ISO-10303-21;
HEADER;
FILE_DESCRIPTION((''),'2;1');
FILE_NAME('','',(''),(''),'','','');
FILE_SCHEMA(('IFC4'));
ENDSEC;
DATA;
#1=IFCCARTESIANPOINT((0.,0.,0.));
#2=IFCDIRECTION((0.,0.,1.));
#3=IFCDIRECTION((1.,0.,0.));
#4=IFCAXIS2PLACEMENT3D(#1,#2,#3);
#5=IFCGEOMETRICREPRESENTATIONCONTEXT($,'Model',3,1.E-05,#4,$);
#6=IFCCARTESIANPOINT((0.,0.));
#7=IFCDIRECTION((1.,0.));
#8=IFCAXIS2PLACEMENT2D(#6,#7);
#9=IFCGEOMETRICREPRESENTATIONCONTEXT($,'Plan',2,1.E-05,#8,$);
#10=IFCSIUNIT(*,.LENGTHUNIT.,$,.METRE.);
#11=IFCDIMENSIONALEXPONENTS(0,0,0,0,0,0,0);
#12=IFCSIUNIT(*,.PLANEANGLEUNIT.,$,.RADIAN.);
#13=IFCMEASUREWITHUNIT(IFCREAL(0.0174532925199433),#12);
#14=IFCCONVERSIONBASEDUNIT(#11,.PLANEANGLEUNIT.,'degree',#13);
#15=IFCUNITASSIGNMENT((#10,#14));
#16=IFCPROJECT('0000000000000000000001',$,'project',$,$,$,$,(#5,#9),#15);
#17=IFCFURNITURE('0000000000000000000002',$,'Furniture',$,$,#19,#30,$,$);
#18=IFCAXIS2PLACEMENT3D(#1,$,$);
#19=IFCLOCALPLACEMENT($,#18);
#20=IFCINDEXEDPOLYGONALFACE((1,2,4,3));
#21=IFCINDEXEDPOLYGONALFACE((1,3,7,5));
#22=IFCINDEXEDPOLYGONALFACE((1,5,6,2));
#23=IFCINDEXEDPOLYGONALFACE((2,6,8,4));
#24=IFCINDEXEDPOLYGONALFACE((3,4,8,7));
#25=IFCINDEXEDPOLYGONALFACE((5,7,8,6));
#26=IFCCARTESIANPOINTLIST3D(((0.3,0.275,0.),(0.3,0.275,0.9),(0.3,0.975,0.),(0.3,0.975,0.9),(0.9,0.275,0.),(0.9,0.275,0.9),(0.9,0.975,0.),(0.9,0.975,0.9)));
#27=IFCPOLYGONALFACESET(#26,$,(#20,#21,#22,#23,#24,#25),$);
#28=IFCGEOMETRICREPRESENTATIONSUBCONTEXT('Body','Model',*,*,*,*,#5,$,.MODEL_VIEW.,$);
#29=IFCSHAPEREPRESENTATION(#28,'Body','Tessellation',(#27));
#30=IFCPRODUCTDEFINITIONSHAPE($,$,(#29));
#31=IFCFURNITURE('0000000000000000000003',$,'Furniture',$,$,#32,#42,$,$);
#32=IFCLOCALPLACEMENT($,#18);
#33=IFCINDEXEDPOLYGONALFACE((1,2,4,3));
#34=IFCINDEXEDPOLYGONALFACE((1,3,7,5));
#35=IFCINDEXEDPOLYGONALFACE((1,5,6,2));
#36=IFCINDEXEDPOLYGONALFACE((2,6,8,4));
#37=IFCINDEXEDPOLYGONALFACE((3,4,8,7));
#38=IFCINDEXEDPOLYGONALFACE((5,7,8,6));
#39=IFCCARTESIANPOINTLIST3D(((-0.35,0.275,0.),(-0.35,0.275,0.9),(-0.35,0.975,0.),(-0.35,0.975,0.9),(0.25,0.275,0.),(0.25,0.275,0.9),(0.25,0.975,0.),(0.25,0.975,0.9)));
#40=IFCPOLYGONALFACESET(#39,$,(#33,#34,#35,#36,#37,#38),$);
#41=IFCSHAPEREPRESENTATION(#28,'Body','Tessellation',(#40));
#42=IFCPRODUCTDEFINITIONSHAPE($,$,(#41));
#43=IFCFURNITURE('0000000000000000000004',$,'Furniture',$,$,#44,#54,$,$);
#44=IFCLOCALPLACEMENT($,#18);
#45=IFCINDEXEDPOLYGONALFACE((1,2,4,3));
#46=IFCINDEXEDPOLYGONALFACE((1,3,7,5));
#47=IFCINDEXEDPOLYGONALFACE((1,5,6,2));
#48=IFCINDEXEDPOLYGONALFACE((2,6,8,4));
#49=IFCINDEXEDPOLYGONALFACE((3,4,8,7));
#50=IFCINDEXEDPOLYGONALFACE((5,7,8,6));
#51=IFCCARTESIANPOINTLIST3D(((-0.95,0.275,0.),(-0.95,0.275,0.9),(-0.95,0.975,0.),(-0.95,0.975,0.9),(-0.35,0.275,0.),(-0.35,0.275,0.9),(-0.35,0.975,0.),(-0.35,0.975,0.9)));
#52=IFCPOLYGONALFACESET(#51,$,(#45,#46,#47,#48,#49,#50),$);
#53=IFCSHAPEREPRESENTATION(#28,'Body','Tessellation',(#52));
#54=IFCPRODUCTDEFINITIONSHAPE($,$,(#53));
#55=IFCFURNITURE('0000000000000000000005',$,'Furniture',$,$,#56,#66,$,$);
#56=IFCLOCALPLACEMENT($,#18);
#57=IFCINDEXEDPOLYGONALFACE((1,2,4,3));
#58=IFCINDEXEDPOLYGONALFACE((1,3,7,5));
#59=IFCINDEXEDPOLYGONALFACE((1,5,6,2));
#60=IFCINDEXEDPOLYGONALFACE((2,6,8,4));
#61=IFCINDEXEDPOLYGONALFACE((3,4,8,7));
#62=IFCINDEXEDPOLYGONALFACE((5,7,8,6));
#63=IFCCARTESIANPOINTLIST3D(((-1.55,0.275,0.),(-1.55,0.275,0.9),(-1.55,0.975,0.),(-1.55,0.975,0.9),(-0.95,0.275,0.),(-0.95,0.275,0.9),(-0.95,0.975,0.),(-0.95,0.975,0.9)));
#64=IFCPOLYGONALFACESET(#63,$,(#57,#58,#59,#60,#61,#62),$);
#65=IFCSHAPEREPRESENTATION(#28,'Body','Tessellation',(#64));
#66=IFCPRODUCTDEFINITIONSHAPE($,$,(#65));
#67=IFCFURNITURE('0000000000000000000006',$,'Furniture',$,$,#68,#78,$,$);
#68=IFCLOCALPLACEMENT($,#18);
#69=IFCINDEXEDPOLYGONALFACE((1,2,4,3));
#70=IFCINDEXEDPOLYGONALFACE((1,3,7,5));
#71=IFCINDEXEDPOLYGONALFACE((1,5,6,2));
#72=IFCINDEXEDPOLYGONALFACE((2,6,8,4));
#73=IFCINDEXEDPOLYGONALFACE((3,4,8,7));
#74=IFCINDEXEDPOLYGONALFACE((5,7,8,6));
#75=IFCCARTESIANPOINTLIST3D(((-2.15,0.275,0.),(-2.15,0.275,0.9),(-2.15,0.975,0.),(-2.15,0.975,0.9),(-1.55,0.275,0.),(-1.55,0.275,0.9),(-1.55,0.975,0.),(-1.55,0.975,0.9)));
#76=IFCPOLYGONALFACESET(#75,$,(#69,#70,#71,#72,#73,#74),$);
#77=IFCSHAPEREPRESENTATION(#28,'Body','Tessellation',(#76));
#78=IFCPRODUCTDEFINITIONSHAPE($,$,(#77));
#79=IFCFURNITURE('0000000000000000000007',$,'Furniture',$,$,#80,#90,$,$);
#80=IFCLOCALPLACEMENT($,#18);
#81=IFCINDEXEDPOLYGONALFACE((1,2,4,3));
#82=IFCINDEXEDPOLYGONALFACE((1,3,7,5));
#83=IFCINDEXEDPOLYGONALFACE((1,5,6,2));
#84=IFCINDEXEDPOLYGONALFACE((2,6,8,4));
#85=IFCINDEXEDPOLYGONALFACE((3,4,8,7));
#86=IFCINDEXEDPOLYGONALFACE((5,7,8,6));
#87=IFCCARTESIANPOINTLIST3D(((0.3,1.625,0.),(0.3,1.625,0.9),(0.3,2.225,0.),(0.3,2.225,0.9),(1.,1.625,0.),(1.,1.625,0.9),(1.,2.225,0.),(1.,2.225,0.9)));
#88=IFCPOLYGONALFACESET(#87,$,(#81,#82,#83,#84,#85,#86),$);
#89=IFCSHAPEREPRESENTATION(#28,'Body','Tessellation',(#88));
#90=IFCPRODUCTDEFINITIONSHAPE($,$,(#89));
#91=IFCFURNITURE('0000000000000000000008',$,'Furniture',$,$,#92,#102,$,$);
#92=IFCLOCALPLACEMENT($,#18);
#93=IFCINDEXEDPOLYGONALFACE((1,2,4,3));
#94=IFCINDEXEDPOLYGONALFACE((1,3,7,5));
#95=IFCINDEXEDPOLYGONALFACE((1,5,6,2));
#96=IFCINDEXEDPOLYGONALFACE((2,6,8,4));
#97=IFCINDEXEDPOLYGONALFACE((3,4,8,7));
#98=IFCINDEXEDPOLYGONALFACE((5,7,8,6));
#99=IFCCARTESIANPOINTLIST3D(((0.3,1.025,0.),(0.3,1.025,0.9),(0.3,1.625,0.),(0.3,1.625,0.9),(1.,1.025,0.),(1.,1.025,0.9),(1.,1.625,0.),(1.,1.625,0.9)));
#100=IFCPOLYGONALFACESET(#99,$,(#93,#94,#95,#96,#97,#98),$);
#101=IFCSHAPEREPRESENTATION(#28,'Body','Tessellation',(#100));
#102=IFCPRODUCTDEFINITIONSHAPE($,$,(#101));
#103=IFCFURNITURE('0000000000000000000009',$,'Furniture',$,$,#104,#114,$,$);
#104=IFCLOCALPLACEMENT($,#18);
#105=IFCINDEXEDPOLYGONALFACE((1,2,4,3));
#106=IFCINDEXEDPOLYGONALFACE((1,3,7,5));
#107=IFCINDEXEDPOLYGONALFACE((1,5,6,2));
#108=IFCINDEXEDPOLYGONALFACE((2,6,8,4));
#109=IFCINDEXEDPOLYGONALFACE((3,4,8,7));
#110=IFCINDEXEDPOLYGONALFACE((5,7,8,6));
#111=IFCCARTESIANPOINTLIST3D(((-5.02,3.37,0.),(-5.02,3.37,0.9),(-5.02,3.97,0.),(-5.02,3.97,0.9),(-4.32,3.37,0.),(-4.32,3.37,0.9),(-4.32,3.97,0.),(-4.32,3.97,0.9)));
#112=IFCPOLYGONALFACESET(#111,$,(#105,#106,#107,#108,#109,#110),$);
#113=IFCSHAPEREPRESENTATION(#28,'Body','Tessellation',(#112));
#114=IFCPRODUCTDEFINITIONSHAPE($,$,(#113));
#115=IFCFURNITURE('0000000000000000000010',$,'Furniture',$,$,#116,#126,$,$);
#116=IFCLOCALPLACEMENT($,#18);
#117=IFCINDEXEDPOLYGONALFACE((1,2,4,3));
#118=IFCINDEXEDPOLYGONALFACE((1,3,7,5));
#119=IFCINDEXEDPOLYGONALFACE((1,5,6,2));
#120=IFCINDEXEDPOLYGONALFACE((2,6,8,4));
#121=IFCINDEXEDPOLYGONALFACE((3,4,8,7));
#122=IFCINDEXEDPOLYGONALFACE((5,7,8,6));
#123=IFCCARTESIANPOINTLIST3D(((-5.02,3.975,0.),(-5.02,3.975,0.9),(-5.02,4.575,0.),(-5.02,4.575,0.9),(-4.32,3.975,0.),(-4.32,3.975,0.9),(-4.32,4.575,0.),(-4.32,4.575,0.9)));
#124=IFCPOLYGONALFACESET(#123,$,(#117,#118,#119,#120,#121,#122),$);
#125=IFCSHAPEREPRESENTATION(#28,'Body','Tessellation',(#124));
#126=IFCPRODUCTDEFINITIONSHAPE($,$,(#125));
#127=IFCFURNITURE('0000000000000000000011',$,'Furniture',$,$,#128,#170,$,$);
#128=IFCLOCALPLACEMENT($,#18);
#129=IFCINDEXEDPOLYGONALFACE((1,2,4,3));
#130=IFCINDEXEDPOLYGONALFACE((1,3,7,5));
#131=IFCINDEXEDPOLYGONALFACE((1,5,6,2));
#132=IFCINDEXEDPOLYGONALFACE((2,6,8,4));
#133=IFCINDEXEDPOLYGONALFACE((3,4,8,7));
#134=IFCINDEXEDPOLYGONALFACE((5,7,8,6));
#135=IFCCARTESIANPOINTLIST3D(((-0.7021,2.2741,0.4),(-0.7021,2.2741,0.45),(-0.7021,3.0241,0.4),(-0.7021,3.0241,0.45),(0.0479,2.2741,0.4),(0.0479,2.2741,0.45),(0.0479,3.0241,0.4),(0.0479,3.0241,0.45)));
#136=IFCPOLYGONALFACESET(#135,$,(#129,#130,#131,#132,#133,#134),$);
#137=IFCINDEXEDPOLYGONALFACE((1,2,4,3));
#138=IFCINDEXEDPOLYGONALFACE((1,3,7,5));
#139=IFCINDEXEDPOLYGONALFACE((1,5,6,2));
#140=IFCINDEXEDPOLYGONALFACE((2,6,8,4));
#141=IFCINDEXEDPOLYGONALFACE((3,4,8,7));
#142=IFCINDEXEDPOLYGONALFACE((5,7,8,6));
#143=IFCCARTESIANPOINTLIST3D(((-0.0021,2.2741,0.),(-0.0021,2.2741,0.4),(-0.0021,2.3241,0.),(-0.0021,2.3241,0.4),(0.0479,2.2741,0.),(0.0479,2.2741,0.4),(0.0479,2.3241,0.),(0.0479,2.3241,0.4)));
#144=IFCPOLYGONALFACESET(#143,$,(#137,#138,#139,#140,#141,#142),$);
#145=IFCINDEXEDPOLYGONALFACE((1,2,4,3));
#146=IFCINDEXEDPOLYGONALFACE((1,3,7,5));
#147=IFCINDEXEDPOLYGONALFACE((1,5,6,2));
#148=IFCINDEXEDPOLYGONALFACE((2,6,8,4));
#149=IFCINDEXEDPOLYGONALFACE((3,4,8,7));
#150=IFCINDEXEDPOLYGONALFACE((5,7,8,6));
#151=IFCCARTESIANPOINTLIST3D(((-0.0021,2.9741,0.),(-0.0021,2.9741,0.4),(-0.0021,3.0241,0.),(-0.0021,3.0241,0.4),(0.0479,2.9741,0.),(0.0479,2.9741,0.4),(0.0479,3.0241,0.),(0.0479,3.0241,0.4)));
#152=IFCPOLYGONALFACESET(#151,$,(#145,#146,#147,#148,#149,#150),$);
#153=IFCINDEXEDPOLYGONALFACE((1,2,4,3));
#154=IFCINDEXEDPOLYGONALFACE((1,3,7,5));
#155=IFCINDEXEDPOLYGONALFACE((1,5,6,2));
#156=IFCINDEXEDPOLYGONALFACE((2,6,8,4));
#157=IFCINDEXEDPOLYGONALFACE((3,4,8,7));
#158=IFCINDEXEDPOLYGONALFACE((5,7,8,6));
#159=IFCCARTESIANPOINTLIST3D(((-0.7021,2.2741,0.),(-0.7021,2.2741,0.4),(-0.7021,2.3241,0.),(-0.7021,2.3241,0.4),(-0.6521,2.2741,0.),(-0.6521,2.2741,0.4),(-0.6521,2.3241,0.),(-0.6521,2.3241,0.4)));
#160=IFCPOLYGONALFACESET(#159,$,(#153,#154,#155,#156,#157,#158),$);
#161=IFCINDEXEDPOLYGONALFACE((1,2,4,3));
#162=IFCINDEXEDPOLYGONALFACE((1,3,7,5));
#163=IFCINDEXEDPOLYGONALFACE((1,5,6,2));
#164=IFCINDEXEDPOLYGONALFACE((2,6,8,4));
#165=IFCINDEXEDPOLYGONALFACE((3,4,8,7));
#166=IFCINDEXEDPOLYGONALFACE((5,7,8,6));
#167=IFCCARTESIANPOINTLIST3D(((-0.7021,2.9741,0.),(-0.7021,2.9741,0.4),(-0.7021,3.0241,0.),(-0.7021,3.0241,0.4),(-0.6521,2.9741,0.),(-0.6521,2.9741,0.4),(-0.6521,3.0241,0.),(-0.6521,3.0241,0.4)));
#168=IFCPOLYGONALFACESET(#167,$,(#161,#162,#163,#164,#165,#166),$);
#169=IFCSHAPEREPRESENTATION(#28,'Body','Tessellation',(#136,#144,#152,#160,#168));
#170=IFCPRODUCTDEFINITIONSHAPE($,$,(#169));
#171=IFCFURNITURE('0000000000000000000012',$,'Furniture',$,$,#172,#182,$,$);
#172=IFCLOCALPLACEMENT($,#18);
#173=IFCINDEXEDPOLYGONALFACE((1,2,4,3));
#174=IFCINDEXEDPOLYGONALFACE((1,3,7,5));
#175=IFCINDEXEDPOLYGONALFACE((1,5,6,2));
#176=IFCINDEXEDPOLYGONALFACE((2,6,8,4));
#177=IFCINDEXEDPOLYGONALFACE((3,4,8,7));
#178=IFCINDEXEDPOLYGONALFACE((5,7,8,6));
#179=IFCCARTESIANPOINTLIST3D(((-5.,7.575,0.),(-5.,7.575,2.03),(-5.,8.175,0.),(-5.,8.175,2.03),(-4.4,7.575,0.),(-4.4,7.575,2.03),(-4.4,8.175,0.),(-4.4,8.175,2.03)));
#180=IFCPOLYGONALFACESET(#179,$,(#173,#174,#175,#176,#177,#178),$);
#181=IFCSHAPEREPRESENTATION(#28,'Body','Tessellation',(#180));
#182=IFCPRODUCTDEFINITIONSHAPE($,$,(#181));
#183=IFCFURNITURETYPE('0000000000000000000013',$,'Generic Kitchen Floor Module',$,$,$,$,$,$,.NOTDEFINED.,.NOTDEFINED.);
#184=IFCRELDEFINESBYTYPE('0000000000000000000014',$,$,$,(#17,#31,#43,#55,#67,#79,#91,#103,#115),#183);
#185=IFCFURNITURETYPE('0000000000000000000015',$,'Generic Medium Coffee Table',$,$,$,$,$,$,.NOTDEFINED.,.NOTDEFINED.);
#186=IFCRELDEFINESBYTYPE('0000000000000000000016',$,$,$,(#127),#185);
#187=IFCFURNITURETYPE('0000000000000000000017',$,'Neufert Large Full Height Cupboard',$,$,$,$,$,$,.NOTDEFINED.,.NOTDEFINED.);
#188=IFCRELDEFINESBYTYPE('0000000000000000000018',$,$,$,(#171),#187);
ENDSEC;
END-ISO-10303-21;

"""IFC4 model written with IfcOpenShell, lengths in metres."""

from ifc_helpers import new_model, entity, si_unit, converted_unit, frame, origin_with_axes, origin_2d_with_axis, place, context, subcontext, project, line, indexed_curve, outline, extrude, shape, source, transform, mapped, type_object, type_shapes, element, save


model = new_model("IFC4")

# Units and contexts
model_context = context("Model", 3, precision=1e-05, world=origin_with_axes())
plan_context = context("Plan", 2, precision=1e-05, world=origin_2d_with_axis())
body_context_1 = subcontext(model_context, "Body", "Model", "MODEL_VIEW")
body_context_2 = subcontext(plan_context, "Body", "Plan", "PLAN_VIEW")
ifc_project = project(units=[si_unit("LENGTHUNIT", "METRE"), converted_unit("PLANEANGLEUNIT", "degree", entity("IfcReal", 0.0174532925199433), si_unit("PLANEANGLEUNIT", "RADIAN"), dimensions=[0, 0, 0, 0, 0, 0, 0])], contexts=[model_context, plan_context])

# Furniture
furniture_type_1 = type_object("IfcFurnitureType", Name="Generic Kitchen Floor Module", AssemblyPlace="NOTDEFINED", PredefinedType="NOTDEFINED")
shared_shape_1 = source(origin_with_axes(), body_context_1, "Body", "SweptSolid", [
    extrude(outline(indexed_curve([(0.0, 0.0), (0.6, 0.0), (0.6, 0.7), (0.0, 0.7)], segments=[line(1, 2, 3, 4, 1)])), origin_with_axes(), (0.0, 0.0, 1.0), 0.9),
])
shared_shape_2 = source(origin_with_axes(), body_context_2, "Body", "Curve2D", [
    entity("IfcIndexedPolyCurve", entity("IfcCartesianPointList2D", [[0.0, 0.0], [0.6, 0.0], [0.6, 0.7], [0.0, 0.7]]), [entity("IfcLineIndex", [1, 2, 3, 4, 1])]),
])
type_shapes(furniture_type_1, [shared_shape_1, shared_shape_2])
for number, where, z_axis, x_axis, name in (
    (1, (0.9, 0.975, 0.0), (0.0, 0.0, 1.0), (-1.0, 0.0, 0.0), "Furniture"),
    (2, (0.25, 0.975, 0.0), (0.0, 0.0, 1.0), (-1.0, 0.0, 0.0), "Furniture"),
    (3, (-0.35, 0.975, 0.0), (0.0, 0.0, 1.0), (-1.0, 0.0, 0.0), "Furniture"),
    (4, (-0.95, 0.975, 0.0), (0.0, 0.0, 1.0), (-1.0, 0.0, 0.0), "Furniture"),
    (5, (-1.55, 0.975, 0.0), (0.0, 0.0, 1.0), (-1.0, 0.0, 0.0), "Furniture"),
    (6, (0.3, 2.225, 0.0), (0.0, 0.0, 1.0), (0.0, -1.0, 0.0), "Furniture"),
    (7, (0.3, 1.625, 0.0), (0.0, 0.0, 1.0), (0.0, -1.0, 0.0), "Furniture"),
    (8, (-4.32, 3.37, 0.0), (0.0, 0.0, 1.0), (0.0, 1.0, 0.0), "Furniture"),
    (9, (-4.32, 3.975, 0.0), (0.0, 0.0, 1.0), (0.0, 1.0, 0.0), "Furniture"),
):
    element("IfcFurniture", number, at=place(None, frame(where, z_axis=z_axis, x_axis=x_axis)), type_object=furniture_type_1, Name=name, shapes=[
        shape(body_context_1, "Body", "MappedRepresentation", [mapped(shared_shape_1, transform((0.0, 0.0, 0.0), x_axis=(1.0, 0.0, 0.0), y_axis=(0.0, 1.0, 0.0), z_axis=(0.0, 0.0, 1.0), scale=1.0))]),
        shape(body_context_2, "Body", "MappedRepresentation", [mapped(shared_shape_2, transform((0.0, 0.0, 0.0), x_axis=(1.0, 0.0, 0.0), y_axis=(0.0, 1.0, 0.0), z_axis=(0.0, 0.0, 1.0), scale=1.0))]),
    ])
furniture_type_2 = type_object("IfcFurnitureType", Name="Generic Medium Coffee Table", AssemblyPlace="NOTDEFINED", PredefinedType="NOTDEFINED")
shared_shape_3 = source(origin_with_axes(), body_context_1, "Body", "SweptSolid", [
    extrude(outline(indexed_curve([(0.0, 0.0), (0.75, 0.0), (0.75, 0.75), (0.0, 0.75)], segments=[line(1, 2, 3, 4, 1)])), frame((-0.375, -0.375, 0.4), z_axis=(0.0, 0.0, 1.0), x_axis=(1.0, 0.0, 0.0)), (0.0, 0.0, 1.0), 0.05),
    extrude(outline(indexed_curve([(0.0, 0.0), (0.05, 0.0), (0.05, 0.05), (0.0, 0.05)], segments=[line(1, 2, 3, 4, 1)])), frame((-0.375, -0.375, 0.0), z_axis=(0.0, 0.0, 1.0), x_axis=(1.0, 0.0, 0.0)), (0.0, 0.0, 1.0), 0.4),
    extrude(outline(indexed_curve([(0.75, 0.0), (0.7, 0.0), (0.7, 0.05), (0.75, 0.05)], segments=[line(1, 2, 3, 4, 1)])), frame((-0.375, -0.375, 0.0), z_axis=(0.0, 0.0, 1.0), x_axis=(1.0, 0.0, 0.0)), (0.0, 0.0, 1.0), 0.4),
    extrude(outline(indexed_curve([(0.0, 0.75), (0.05, 0.75), (0.05, 0.7), (0.0, 0.7)], segments=[line(1, 2, 3, 4, 1)])), frame((-0.375, -0.375, 0.0), z_axis=(0.0, 0.0, 1.0), x_axis=(1.0, 0.0, 0.0)), (0.0, 0.0, 1.0), 0.4),
    extrude(outline(indexed_curve([(0.75, 0.75), (0.7, 0.75), (0.7, 0.7), (0.75, 0.7)], segments=[line(1, 2, 3, 4, 1)])), frame((-0.375, -0.375, 0.0), z_axis=(0.0, 0.0, 1.0), x_axis=(1.0, 0.0, 0.0)), (0.0, 0.0, 1.0), 0.4),
])
shared_shape_4 = source(origin_with_axes(), body_context_2, "Body", "Curve2D", [
    entity("IfcIndexedPolyCurve", entity("IfcCartesianPointList2D", [[-0.375, -0.375], [0.375, -0.375], [0.375, 0.375], [-0.375, 0.375]]), [entity("IfcLineIndex", [1, 2, 3, 4, 1])]),
])
type_shapes(furniture_type_2, [shared_shape_3, shared_shape_4])
furniture_1_placement = place(None, frame((-0.3271, 2.6491, 0.0), z_axis=(0.0, 0.0, 1.0), x_axis=(0.0, 1.0, 0.0)))
element("IfcFurniture", 10, at=furniture_1_placement, type_object=furniture_type_2, Name="Furniture", shapes=[
    shape(body_context_1, "Body", "MappedRepresentation", [mapped(shared_shape_3, transform((0.0, 0.0, 0.0), x_axis=(1.0, 0.0, 0.0), y_axis=(0.0, 1.0, 0.0), z_axis=(0.0, 0.0, 1.0), scale=1.0))]),
    shape(body_context_2, "Body", "MappedRepresentation", [mapped(shared_shape_4, transform((0.0, 0.0, 0.0), x_axis=(1.0, 0.0, 0.0), y_axis=(0.0, 1.0, 0.0), z_axis=(0.0, 0.0, 1.0), scale=1.0))]),
])
furniture_type_3 = type_object("IfcFurnitureType", Name="Neufert Large Full Height Cupboard", AssemblyPlace="NOTDEFINED", PredefinedType="NOTDEFINED")
shared_shape_5 = source(origin_with_axes(), body_context_1, "Body", "SweptSolid", [
    extrude(outline(indexed_curve([(0.0, 0.0), (0.6, 0.0), (0.6, 0.6), (0.0, 0.6)], segments=[line(1, 2, 3, 4, 1)])), origin_with_axes(), (0.0, 0.0, 1.0), 2.03),
])
shared_shape_6 = source(origin_with_axes(), body_context_2, "Body", "Curve2D", [
    entity("IfcIndexedPolyCurve", entity("IfcCartesianPointList2D", [[0.0, 0.0], [0.6, 0.0], [0.6, 0.6], [0.0, 0.6]]), [entity("IfcLineIndex", [1, 2, 3, 4, 1])]),
])
type_shapes(furniture_type_3, [shared_shape_5, shared_shape_6])
furniture_2_placement = place(None, frame((-5.0, 7.575, 0.0), z_axis=(0.0, 0.0, 1.0), x_axis=(1.0, 0.0, 0.0)))
element("IfcFurniture", 11, at=furniture_2_placement, type_object=furniture_type_3, Name="Furniture", shapes=[
    shape(body_context_1, "Body", "MappedRepresentation", [mapped(shared_shape_5, transform((0.0, 0.0, 0.0), x_axis=(1.0, 0.0, 0.0), y_axis=(0.0, 1.0, 0.0), z_axis=(0.0, 0.0, 1.0), scale=1.0))]),
    shape(body_context_2, "Body", "MappedRepresentation", [mapped(shared_shape_6, transform((0.0, 0.0, 0.0), x_axis=(1.0, 0.0, 0.0), y_axis=(0.0, 1.0, 0.0), z_axis=(0.0, 0.0, 1.0), scale=1.0))]),
])

save(model, "model.ifc")
